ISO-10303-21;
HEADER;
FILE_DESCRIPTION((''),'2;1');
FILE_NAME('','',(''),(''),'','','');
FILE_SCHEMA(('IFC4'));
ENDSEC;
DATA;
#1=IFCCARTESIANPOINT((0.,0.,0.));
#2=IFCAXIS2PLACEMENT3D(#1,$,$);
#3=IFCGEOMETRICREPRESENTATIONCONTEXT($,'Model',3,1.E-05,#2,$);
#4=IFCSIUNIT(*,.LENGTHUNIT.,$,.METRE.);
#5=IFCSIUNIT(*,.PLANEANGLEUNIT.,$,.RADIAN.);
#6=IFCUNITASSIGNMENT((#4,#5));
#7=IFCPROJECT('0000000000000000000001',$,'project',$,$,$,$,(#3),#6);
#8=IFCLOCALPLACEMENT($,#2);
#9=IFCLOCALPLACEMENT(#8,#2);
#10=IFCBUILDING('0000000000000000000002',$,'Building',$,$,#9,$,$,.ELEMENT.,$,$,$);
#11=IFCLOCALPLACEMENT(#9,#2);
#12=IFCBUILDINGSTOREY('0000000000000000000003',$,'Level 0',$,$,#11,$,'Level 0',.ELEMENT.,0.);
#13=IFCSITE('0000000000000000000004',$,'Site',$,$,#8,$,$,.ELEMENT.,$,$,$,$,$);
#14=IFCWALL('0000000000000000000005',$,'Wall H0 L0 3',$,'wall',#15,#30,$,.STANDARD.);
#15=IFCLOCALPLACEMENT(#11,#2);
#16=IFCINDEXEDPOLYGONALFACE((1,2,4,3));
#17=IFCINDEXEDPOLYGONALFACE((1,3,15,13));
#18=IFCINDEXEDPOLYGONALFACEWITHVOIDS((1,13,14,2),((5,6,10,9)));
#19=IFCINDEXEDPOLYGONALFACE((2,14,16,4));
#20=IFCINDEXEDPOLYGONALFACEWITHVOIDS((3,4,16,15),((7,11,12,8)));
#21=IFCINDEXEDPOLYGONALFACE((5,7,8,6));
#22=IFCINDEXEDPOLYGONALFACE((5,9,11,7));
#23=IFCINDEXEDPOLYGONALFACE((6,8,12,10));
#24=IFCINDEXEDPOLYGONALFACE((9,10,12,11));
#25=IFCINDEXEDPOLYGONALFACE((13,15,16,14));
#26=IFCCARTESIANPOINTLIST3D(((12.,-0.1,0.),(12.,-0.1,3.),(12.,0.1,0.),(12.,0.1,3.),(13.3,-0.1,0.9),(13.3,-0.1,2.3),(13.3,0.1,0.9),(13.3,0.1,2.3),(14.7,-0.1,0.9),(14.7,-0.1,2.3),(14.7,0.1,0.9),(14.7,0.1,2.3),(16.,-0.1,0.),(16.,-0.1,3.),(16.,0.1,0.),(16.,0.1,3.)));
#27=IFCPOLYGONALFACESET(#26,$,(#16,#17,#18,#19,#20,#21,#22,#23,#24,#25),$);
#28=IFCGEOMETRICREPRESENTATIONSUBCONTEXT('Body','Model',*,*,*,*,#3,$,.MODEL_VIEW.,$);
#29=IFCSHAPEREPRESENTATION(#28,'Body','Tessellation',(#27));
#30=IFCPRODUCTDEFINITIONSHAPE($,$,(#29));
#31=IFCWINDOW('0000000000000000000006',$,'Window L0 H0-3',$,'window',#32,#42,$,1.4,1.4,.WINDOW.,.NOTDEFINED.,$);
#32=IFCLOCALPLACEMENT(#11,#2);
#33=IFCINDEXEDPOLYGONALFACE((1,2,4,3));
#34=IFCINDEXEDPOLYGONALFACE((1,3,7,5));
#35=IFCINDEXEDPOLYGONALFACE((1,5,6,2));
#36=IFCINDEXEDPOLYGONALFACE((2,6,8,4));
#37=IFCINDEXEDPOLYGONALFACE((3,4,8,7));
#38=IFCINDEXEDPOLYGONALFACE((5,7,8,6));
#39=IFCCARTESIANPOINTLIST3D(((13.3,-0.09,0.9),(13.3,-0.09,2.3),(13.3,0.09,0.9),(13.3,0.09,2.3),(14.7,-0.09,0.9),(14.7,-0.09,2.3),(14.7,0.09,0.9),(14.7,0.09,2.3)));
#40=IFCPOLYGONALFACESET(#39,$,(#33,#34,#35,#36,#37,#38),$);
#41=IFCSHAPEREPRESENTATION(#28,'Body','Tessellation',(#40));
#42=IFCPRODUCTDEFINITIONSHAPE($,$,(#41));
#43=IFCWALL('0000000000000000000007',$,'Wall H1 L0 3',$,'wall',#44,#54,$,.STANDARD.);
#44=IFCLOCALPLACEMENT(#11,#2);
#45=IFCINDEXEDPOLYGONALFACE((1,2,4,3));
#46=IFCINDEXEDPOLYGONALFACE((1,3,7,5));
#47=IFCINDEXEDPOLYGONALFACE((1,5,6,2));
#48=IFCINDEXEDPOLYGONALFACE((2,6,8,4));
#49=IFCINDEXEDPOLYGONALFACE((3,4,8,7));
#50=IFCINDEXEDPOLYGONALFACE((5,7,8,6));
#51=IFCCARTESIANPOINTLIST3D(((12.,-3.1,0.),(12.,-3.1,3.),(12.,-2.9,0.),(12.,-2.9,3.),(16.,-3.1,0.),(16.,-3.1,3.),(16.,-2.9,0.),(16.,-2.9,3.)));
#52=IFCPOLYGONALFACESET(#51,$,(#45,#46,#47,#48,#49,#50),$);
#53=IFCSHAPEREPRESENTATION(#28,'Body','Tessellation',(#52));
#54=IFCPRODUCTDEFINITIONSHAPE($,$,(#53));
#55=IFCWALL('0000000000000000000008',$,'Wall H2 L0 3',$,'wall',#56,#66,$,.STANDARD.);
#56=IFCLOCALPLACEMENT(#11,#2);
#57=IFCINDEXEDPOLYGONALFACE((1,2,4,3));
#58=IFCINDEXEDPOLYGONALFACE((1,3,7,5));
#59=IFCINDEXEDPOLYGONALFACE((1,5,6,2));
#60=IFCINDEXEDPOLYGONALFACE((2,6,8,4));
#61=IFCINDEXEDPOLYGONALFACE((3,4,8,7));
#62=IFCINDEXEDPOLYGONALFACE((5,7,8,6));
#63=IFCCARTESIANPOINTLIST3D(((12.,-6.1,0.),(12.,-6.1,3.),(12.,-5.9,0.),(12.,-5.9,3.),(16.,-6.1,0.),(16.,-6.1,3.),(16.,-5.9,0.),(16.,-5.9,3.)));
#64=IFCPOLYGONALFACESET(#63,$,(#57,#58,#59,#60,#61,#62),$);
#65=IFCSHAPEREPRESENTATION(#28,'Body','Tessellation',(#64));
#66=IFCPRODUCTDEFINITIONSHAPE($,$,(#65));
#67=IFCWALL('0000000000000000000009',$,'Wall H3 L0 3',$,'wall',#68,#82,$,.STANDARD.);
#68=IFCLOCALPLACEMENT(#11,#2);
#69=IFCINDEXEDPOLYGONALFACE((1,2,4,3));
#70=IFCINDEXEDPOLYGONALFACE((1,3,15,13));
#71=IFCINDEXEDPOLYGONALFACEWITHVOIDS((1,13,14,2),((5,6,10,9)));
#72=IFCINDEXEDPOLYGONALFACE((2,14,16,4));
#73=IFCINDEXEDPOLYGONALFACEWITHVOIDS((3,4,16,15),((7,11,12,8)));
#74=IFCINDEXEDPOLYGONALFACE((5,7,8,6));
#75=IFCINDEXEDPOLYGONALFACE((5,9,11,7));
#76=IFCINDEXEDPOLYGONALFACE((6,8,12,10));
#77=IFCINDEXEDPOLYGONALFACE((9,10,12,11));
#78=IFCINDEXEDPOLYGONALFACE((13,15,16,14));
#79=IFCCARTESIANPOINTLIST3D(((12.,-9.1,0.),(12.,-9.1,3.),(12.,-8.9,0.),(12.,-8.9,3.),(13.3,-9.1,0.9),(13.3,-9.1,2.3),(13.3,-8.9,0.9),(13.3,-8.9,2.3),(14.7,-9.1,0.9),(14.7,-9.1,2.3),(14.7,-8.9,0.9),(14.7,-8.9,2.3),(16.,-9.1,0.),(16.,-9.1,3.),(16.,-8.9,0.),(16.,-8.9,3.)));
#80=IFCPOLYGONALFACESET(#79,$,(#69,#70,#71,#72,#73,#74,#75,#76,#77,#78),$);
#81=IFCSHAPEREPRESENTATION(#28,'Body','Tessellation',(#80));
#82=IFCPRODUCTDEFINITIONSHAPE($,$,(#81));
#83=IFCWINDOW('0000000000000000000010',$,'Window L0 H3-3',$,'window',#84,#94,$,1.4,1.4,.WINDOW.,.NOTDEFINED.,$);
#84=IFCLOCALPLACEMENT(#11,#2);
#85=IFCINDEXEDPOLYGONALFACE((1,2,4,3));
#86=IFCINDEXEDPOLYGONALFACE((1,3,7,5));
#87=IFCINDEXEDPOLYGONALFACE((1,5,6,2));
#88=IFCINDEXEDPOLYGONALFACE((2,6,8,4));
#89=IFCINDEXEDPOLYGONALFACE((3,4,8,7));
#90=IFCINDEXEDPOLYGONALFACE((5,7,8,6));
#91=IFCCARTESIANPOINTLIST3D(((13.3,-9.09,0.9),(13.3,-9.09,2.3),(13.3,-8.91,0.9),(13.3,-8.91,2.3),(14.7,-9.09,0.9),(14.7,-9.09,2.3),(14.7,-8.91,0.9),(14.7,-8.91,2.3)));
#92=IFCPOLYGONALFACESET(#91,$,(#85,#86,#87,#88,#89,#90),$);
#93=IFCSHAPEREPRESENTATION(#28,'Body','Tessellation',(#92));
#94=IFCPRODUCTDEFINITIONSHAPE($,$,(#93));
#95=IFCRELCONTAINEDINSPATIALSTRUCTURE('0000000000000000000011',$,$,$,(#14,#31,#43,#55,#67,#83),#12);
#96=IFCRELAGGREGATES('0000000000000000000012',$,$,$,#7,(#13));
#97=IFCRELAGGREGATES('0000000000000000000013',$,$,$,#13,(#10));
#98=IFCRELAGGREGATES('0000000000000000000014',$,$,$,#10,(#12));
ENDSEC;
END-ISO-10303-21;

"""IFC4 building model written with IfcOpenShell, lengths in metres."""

from ifc_helpers import new_model, si_unit, frame, frame_2d, origin, origin_2d, place, context, subcontext, project, spatial, rectangle, extrude, element, fill, save


model = new_model("IFC4")

# Units and contexts
model_context = context("Model", 3, precision=1e-05, world=origin())
body_context = subcontext(model_context, "Body", "Model", "MODEL_VIEW")
ifc_project = project(units=[si_unit("LENGTHUNIT", "METRE"), si_unit("PLANEANGLEUNIT", "RADIAN")], contexts=[model_context])

# Site, building, storey
site_placement = place(None, origin())
site = spatial("IfcSite", under=ifc_project, at=site_placement, Name="Site", CompositionType="ELEMENT")
building_placement = place(site_placement, origin())
building = spatial("IfcBuilding", under=site, at=building_placement, Name="Building", CompositionType="ELEMENT")
storey_placement = place(building_placement, origin())
storey = spatial("IfcBuildingStorey", under=building, at=storey_placement, Name="Level 0", LongName="Level 0", CompositionType="ELEMENT", Elevation=0.0)

# Wall, opening, window
wall_1_placement = place(storey_placement, frame((12.0, 0.0, 0.0), z_axis=(0.0, 0.0, 1.0), x_axis=(1.0, 0.0, 0.0)))
wall_1 = element("IfcWall", 1, at=wall_1_placement, inside=storey, Name="Wall H0 L0 3", ObjectType="wall", PredefinedType="STANDARD", context=body_context, shape_type="SweptSolid", body=[
    extrude(rectangle(XDim=4.0, YDim=0.2, at=frame_2d((2.0, 0.0))), origin(), (0.0, 0.0, 1.0), 3.0),
])
opening_1_placement = place(storey_placement, frame((14.0, 0.0, 0.9), z_axis=(0.0, 0.0, 1.0), x_axis=(1.0, 0.0, 0.0)))
opening_1 = element("IfcOpeningElement", 2, at=opening_1_placement, cuts=wall_1, ObjectType="Opening", PredefinedType="OPENING", context=body_context, shape_type="SweptSolid", body=[
    extrude(rectangle(XDim=1.4, YDim=0.22, at=origin_2d()), origin(), (0.0, 0.0, 1.0), 1.4),
])
window_1_placement = place(storey_placement, frame((14.0, 0.0, 0.9), z_axis=(0.0, 0.0, 1.0), x_axis=(1.0, 0.0, 0.0)))
window_1 = element("IfcWindow", 3, at=window_1_placement, inside=storey, Name="Window L0 H0-3", ObjectType="window", OverallHeight=1.4, OverallWidth=1.4, PartitioningType="NOTDEFINED", PredefinedType="WINDOW", context=body_context, shape_type="SweptSolid", body=[
    extrude(rectangle(XDim=1.4, YDim=0.18, at=origin_2d()), origin(), (0.0, 0.0, 1.0), 1.4),
])
fill(opening_1, window_1)

# Walls
for number, where, z_axis, x_axis, name in (
    (4, (12.0, -3.0, 0.0), (0.0, 0.0, 1.0), (1.0, 0.0, 0.0), "Wall H1 L0 3"),
    (5, (12.0, -6.0, 0.0), (0.0, 0.0, 1.0), (1.0, 0.0, 0.0), "Wall H2 L0 3"),
):
    element("IfcWall", number, at=place(storey_placement, frame(where, z_axis=z_axis, x_axis=x_axis)), inside=storey, Name=name, ObjectType="wall", PredefinedType="STANDARD", context=body_context, shape_type="SweptSolid", body=[
        extrude(rectangle(XDim=4.0, YDim=0.2, at=frame_2d((2.0, 0.0))), origin(), (0.0, 0.0, 1.0), 3.0),
    ])

# Wall, opening, window
wall_2_placement = place(storey_placement, frame((12.0, -9.0, 0.0), z_axis=(0.0, 0.0, 1.0), x_axis=(1.0, 0.0, 0.0)))
wall_2 = element("IfcWall", 6, at=wall_2_placement, inside=storey, Name="Wall H3 L0 3", ObjectType="wall", PredefinedType="STANDARD", context=body_context, shape_type="SweptSolid", body=[
    extrude(rectangle(XDim=4.0, YDim=0.2, at=frame_2d((2.0, 0.0))), origin(), (0.0, 0.0, 1.0), 3.0),
])
opening_2_placement = place(storey_placement, frame((14.0, -9.0, 0.9), z_axis=(0.0, 0.0, 1.0), x_axis=(1.0, 0.0, 0.0)))
opening_2 = element("IfcOpeningElement", 7, at=opening_2_placement, cuts=wall_2, ObjectType="Opening", PredefinedType="OPENING", context=body_context, shape_type="SweptSolid", body=[
    extrude(rectangle(XDim=1.4, YDim=0.22, at=origin_2d()), origin(), (0.0, 0.0, 1.0), 1.4),
])
window_2_placement = place(storey_placement, frame((14.0, -9.0, 0.9), z_axis=(0.0, 0.0, 1.0), x_axis=(1.0, 0.0, 0.0)))
window_2 = element("IfcWindow", 8, at=window_2_placement, inside=storey, Name="Window L0 H3-3", ObjectType="window", OverallHeight=1.4, OverallWidth=1.4, PartitioningType="NOTDEFINED", PredefinedType="WINDOW", context=body_context, shape_type="SweptSolid", body=[
    extrude(rectangle(XDim=1.4, YDim=0.18, at=origin_2d()), origin(), (0.0, 0.0, 1.0), 1.4),
])
fill(opening_2, window_2)

save(model, "model.ifc")
